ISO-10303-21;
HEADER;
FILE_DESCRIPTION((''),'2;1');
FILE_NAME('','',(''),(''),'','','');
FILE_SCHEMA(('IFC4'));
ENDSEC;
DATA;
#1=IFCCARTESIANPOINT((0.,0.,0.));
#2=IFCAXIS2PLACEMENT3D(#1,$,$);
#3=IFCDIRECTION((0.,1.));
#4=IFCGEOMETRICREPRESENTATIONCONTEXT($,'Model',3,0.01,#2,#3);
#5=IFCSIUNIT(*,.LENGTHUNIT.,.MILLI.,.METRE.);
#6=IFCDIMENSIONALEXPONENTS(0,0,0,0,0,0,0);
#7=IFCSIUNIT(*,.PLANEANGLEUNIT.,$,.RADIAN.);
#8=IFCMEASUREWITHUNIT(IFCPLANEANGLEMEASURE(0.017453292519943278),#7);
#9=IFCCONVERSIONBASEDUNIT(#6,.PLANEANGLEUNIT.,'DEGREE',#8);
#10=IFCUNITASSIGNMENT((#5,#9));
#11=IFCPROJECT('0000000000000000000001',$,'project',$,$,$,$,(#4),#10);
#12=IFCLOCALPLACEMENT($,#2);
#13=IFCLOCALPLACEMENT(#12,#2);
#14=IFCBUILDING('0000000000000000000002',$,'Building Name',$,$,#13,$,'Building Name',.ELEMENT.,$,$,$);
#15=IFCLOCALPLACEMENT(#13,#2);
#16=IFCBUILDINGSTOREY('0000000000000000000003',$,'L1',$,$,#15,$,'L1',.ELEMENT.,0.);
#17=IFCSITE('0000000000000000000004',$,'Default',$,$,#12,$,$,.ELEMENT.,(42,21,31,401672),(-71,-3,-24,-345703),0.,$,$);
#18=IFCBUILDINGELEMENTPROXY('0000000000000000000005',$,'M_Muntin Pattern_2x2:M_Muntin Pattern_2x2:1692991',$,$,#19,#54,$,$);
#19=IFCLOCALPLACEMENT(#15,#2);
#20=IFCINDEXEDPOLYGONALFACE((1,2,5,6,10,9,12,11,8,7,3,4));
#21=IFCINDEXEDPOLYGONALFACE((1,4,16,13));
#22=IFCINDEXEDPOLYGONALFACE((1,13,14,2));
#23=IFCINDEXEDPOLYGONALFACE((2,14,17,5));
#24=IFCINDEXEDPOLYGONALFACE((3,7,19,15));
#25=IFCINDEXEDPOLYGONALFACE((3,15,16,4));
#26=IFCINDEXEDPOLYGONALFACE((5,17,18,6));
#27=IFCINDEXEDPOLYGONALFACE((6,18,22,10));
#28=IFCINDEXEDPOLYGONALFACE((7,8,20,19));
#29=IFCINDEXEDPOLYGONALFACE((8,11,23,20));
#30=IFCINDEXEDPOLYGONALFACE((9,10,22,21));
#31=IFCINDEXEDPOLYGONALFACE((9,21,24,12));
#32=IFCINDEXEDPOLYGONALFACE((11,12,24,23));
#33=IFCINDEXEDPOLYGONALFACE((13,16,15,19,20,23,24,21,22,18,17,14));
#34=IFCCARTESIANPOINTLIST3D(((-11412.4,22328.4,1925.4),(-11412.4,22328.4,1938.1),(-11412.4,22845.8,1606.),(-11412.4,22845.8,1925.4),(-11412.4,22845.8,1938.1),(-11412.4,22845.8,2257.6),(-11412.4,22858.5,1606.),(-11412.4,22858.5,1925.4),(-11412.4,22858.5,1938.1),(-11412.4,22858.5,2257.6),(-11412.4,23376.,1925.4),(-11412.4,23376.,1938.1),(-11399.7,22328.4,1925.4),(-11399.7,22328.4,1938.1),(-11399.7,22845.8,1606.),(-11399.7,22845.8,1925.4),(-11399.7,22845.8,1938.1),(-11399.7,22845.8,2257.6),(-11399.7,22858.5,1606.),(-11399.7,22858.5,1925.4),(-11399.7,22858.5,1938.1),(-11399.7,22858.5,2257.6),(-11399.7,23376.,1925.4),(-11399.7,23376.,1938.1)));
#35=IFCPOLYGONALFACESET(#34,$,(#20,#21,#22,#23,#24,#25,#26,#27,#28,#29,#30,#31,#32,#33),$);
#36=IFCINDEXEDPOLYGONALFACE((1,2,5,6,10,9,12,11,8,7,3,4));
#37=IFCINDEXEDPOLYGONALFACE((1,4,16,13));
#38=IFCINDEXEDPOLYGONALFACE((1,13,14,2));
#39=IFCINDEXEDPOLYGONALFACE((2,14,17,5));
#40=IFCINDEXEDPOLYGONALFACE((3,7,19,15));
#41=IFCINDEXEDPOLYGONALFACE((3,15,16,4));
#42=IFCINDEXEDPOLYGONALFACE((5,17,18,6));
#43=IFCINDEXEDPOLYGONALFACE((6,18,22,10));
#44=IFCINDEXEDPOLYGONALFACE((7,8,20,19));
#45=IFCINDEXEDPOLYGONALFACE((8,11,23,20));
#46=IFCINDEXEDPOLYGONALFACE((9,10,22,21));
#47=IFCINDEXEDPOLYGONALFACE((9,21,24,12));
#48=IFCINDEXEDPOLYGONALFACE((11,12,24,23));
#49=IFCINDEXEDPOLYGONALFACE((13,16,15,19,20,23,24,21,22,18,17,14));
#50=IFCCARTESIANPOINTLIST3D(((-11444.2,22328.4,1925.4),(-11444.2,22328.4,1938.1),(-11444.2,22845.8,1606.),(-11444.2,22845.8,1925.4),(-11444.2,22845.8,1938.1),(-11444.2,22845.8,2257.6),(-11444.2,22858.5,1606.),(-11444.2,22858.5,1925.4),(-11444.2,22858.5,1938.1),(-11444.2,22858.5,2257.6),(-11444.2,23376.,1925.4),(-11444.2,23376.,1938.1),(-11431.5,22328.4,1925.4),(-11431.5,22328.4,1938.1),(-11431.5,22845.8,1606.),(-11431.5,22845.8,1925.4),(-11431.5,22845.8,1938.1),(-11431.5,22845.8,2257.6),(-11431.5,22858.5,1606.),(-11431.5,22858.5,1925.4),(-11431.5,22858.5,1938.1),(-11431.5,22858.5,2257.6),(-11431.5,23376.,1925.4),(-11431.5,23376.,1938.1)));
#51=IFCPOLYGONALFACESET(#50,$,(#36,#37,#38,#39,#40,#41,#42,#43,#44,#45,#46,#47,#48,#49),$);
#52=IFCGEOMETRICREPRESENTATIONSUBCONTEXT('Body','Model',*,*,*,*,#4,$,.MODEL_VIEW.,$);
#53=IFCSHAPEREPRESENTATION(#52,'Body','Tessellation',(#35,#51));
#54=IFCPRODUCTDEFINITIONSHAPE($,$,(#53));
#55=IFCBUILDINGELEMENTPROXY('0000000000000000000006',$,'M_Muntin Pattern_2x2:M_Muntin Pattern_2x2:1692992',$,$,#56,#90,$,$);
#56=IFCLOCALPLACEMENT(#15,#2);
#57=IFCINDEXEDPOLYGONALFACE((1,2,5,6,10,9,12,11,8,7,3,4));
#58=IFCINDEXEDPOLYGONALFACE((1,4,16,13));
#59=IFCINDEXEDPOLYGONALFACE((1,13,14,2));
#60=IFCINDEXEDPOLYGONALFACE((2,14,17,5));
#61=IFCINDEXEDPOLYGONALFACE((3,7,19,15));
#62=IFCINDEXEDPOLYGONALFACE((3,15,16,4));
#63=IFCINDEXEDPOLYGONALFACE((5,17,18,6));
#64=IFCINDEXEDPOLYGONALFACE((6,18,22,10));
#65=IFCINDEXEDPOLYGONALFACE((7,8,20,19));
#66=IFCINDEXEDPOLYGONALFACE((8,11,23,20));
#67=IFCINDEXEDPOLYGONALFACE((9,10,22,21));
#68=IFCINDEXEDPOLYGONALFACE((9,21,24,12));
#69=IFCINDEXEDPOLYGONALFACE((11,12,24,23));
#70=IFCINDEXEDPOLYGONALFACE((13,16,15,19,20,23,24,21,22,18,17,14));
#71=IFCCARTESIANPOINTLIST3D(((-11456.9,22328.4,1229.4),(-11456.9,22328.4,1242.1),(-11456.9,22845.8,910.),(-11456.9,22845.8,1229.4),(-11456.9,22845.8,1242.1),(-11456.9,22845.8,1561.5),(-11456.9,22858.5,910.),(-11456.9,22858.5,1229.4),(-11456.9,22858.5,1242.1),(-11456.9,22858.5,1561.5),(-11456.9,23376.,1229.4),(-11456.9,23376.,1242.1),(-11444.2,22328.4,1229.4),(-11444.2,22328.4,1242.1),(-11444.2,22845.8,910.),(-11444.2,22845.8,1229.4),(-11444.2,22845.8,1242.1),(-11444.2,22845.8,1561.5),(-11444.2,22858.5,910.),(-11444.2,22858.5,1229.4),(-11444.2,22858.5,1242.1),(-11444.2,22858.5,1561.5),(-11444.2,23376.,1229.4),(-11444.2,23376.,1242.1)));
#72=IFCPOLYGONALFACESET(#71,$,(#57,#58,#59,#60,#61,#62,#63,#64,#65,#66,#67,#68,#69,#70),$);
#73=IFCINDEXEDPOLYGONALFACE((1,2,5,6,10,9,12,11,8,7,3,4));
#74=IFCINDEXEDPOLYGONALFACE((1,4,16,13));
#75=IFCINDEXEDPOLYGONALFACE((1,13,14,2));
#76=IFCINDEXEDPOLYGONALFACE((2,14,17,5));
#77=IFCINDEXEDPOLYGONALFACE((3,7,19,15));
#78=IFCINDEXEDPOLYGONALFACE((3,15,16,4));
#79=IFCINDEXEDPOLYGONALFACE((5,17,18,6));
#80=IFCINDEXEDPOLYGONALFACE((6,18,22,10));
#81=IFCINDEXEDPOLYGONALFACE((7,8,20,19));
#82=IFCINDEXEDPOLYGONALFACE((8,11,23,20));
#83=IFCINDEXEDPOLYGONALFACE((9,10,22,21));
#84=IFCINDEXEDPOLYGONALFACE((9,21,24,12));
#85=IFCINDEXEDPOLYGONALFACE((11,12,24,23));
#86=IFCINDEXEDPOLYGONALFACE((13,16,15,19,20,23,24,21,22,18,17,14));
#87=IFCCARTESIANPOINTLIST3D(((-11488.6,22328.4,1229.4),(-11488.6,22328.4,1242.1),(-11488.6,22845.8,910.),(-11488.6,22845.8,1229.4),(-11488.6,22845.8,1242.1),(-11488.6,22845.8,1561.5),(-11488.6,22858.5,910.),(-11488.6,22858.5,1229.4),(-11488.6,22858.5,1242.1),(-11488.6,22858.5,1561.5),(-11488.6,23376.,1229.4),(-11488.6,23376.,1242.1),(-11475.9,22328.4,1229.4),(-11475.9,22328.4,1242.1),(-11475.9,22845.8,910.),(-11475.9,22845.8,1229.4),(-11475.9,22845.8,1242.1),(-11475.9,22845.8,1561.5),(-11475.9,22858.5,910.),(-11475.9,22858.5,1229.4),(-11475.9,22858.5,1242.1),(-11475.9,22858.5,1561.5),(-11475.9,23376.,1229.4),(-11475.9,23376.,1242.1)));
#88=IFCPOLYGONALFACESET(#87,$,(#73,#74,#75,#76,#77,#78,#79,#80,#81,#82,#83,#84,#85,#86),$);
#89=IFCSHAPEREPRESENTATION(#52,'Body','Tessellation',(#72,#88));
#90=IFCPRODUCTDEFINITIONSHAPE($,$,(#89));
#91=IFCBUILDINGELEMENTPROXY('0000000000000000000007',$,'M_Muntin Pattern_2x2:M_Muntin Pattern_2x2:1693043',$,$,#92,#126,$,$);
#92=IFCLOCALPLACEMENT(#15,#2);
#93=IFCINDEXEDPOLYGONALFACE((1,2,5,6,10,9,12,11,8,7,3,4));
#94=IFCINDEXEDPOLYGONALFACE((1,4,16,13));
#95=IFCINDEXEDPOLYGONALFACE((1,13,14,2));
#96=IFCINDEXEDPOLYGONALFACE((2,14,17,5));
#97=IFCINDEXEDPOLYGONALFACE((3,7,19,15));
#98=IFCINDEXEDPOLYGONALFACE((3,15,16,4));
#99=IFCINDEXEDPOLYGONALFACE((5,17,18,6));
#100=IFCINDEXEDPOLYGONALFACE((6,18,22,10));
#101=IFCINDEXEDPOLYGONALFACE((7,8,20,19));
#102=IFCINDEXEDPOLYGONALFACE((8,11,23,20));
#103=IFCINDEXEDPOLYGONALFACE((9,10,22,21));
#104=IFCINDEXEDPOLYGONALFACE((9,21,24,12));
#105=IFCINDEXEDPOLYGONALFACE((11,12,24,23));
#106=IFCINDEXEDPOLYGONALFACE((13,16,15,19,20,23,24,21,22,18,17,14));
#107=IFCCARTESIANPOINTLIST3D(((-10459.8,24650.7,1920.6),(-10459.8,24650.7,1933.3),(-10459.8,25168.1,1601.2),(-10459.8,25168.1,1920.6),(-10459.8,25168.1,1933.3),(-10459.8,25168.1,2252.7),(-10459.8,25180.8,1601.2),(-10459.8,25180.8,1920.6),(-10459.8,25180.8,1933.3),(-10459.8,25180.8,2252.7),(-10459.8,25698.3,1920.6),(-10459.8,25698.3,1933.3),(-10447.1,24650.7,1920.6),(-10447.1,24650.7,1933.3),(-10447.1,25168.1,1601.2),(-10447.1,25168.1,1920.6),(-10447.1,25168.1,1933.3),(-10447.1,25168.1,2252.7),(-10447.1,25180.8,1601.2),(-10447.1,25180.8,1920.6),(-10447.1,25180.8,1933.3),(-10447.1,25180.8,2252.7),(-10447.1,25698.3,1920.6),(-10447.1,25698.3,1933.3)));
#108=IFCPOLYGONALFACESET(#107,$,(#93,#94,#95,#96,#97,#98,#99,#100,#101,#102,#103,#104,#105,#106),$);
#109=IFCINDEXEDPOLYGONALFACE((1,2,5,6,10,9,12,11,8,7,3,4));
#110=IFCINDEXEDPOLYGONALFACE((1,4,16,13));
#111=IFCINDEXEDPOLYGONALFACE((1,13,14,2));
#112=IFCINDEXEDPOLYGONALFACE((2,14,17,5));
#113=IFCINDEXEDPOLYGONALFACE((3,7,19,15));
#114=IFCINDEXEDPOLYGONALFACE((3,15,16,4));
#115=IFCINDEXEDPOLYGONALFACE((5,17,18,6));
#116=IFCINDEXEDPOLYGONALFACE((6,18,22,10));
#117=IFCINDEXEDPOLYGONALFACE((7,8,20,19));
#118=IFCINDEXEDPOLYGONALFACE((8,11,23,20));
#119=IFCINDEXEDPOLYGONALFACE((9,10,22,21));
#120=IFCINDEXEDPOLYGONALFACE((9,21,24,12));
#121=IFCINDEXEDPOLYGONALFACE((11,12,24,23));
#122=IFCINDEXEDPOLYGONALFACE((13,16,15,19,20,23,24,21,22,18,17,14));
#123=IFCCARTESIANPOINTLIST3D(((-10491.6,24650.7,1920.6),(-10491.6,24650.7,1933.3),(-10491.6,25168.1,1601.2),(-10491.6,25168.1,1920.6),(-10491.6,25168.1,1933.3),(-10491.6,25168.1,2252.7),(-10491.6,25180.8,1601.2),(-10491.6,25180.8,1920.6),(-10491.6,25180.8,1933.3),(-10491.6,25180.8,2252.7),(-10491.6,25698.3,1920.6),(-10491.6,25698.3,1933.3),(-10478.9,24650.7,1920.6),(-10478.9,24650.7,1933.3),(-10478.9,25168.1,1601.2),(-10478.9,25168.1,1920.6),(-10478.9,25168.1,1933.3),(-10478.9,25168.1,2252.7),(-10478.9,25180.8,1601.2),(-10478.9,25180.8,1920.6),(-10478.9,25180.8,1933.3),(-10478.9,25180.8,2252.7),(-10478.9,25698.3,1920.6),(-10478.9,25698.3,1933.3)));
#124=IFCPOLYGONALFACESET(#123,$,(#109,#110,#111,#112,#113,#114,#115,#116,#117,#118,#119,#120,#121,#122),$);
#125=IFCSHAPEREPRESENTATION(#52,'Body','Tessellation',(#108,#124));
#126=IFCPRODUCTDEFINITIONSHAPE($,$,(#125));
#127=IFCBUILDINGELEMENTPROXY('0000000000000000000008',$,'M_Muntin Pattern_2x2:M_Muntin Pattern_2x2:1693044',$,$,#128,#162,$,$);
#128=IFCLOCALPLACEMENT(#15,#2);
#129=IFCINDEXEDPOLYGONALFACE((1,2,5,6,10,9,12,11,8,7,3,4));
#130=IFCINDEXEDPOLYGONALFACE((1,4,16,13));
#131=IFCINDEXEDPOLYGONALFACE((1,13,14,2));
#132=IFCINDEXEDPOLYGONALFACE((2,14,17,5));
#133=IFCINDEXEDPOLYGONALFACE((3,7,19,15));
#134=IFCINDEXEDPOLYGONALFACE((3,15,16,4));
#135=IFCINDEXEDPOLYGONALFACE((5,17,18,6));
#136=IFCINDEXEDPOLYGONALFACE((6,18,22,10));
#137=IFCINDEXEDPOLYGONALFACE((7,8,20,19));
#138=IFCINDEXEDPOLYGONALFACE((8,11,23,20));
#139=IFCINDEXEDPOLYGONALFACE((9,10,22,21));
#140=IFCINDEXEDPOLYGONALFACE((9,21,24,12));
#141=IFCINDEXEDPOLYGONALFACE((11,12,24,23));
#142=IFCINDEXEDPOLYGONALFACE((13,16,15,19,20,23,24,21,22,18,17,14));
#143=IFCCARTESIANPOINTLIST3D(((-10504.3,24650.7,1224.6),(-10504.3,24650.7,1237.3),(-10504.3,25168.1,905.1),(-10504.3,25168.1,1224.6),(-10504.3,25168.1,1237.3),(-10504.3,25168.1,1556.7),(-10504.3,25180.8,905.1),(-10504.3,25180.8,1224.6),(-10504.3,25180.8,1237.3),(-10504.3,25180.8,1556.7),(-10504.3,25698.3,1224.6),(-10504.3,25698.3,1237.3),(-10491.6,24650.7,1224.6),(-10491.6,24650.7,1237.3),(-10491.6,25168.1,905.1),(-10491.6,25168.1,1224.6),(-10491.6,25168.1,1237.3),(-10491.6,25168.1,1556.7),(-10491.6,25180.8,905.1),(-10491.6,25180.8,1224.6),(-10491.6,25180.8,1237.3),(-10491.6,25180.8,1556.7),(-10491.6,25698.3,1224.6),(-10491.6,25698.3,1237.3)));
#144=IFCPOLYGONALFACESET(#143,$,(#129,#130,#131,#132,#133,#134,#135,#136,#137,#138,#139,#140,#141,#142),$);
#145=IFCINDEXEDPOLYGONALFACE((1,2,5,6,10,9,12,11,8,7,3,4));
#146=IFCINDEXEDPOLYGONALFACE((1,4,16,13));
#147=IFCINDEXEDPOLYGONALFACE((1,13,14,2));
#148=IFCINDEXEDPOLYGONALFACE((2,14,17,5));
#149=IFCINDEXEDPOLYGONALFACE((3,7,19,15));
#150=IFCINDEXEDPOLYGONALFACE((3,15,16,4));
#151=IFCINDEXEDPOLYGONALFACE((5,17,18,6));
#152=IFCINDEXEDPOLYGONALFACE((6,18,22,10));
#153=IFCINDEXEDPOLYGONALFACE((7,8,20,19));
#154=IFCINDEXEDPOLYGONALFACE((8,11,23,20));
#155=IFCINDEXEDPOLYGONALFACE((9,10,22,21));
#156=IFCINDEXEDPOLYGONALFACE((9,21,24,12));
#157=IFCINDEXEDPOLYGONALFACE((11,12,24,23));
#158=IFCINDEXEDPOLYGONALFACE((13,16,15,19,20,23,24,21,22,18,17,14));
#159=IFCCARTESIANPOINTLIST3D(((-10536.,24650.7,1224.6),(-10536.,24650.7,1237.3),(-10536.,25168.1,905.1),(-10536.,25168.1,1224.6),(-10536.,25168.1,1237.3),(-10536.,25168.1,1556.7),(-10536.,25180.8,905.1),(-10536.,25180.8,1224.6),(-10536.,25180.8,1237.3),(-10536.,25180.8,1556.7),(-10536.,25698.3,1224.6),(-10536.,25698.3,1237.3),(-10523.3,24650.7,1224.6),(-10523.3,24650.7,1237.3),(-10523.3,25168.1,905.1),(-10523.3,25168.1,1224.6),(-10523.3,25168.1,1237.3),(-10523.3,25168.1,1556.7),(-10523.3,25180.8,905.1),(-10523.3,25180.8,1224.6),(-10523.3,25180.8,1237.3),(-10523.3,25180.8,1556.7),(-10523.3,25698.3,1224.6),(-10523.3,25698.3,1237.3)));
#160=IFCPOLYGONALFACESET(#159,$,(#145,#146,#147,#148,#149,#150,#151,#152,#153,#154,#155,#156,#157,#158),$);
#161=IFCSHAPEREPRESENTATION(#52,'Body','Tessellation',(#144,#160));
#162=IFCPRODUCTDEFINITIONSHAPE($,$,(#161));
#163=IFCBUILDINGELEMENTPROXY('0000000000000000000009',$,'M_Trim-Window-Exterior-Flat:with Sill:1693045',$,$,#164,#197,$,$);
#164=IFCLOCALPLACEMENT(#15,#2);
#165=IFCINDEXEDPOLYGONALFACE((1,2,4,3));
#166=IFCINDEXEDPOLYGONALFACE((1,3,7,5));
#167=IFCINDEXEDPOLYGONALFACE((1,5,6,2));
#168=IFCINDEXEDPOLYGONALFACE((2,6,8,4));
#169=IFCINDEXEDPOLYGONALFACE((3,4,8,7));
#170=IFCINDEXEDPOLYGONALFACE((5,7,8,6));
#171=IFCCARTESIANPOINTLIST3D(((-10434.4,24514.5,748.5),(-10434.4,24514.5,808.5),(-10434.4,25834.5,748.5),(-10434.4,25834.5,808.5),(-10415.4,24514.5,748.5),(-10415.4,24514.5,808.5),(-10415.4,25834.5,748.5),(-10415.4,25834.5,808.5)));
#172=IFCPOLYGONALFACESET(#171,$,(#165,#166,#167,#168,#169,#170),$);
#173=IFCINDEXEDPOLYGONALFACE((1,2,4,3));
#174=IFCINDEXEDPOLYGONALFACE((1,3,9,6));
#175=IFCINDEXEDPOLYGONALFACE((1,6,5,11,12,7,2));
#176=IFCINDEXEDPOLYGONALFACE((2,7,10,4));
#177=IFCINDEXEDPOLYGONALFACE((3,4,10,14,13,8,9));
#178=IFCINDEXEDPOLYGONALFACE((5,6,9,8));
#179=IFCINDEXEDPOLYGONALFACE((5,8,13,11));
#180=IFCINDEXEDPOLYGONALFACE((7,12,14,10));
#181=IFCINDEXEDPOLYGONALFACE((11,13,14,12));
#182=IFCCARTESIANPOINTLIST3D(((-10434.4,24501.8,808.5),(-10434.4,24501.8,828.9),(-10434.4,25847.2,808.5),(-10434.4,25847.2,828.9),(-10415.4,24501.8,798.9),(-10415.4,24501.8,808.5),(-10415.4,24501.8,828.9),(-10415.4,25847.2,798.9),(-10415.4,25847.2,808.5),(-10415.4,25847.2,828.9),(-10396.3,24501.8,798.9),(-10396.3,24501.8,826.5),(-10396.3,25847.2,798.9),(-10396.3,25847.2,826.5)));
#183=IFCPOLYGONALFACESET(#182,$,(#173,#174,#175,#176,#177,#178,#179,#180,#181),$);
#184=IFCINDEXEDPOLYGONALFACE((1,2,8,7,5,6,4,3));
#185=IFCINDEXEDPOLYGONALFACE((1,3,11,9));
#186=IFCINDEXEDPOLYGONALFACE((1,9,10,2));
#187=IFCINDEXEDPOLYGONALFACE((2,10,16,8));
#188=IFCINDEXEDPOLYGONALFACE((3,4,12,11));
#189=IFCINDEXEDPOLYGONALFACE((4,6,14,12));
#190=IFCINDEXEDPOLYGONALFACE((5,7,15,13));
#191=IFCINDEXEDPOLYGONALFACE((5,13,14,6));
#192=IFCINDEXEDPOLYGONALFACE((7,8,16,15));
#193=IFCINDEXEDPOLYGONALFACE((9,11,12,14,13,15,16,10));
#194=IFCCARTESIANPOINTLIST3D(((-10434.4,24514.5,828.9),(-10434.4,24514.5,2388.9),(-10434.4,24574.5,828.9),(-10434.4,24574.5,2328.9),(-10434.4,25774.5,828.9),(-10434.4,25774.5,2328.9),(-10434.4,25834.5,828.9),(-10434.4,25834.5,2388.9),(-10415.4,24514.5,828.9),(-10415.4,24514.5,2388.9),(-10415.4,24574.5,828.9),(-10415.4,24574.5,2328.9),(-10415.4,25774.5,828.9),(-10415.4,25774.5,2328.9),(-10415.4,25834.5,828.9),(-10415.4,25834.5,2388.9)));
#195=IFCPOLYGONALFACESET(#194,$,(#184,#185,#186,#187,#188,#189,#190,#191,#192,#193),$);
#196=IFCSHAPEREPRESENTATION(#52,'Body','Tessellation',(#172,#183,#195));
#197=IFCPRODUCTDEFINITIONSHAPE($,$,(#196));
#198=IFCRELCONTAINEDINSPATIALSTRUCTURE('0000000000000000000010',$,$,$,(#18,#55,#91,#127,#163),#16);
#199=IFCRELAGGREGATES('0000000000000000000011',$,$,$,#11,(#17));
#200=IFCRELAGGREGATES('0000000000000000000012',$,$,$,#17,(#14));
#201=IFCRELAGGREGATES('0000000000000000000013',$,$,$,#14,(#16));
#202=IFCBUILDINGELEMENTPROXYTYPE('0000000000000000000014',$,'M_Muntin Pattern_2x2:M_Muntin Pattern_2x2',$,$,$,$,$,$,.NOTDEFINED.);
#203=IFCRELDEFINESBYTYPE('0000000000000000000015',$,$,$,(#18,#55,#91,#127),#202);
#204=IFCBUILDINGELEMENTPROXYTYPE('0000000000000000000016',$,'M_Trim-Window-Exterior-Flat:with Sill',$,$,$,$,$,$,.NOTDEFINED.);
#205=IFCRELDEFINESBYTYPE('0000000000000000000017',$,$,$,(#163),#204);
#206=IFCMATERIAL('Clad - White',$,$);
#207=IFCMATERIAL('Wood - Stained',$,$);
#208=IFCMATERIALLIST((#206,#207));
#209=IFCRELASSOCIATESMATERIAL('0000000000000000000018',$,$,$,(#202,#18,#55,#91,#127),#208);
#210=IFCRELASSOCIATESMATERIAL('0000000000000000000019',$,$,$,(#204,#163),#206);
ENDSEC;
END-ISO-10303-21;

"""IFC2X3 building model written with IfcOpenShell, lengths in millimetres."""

from ifc_helpers import new_model, entity, si_unit, converted_unit, direction, frame, frame_2d, origin, place, context, subcontext, project, spatial, polyline, rectangle, outline, extrude, source, transform, mapped, material, material_list, type_object, type_shapes, element, save


model = new_model("IFC2X3")

# Units and contexts
model_context = context("Model", 3, precision=0.01, world=origin(), true_north=direction((0.0, 1.0)))
body_context = subcontext(model_context, "Body", "Model", "MODEL_VIEW")
ifc_project = project(units=[si_unit("LENGTHUNIT", "METRE", prefix="MILLI"), converted_unit("PLANEANGLEUNIT", "DEGREE", entity("IfcPlaneAngleMeasure", 0.017453292519943278), si_unit("PLANEANGLEUNIT", "RADIAN"), dimensions=[0, 0, 0, 0, 0, 0, 0])], contexts=[model_context])

# Site, building, storey
site_placement = place(None, origin())
site = spatial("IfcSite", under=ifc_project, at=site_placement, Name="Default", CompositionType="ELEMENT", RefLatitude=(42, 21, 31, 401672), RefLongitude=(-71, -3, -24, -345703), RefElevation=0.0)
building_placement = place(site_placement, origin())
building = spatial("IfcBuilding", under=site, at=building_placement, Name="Building Name", LongName="Building Name", CompositionType="ELEMENT")
storey_placement = place(building_placement, origin())
storey = spatial("IfcBuildingStorey", under=building, at=storey_placement, Name="L1", LongName="L1", CompositionType="ELEMENT", Elevation=0.0)

# Shared definitions
ifc_material_1 = material(Name="Wood - Stained")

# Building element proxies
ifc_material_2 = material(Name="Clad - White")
ifc_material_list_1 = material_list([ifc_material_2, ifc_material_1])
building_element_proxy_type_1 = type_object("IfcBuildingElementProxyType", Name="M_Muntin Pattern_2x2:M_Muntin Pattern_2x2", PredefinedType="NOTDEFINED", material=ifc_material_list_1)
shared_shape_1 = source(origin(), body_context, "Body", "SweptSolid", [
    extrude(outline(polyline([(6.4, -6.4), (325.8, -6.4), (325.8, 6.3), (6.4, 6.3), (6.4, 523.8), (-6.3, 523.8), (-6.3, 6.3), (-325.8, 6.3), (-325.8, -6.4), (-6.3, -6.4), (-6.3, -523.8), (6.4, -523.8), (6.4, -6.4)])), frame((0.0, 9.5, 325.8), z_axis=(0.0, 1.0, 0.0), x_axis=(0.0, 0.0, 1.0)), (0.0, 0.0, 1.0), 12.7),
    extrude(outline(polyline([(6.4, -6.4), (325.8, -6.4), (325.8, 6.3), (6.4, 6.3), (6.4, 523.8), (-6.3, 523.8), (-6.3, 6.3), (-325.8, 6.3), (-325.8, -6.4), (-6.3, -6.4), (-6.3, -523.8), (6.4, -523.8), (6.4, -6.4)])), frame((0.0, -22.2, 325.8), z_axis=(0.0, 1.0, 0.0), x_axis=(0.0, 0.0, 1.0)), (0.0, 0.0, 1.0), 12.7),
])
type_shapes(building_element_proxy_type_1, [shared_shape_1])
for number, where, z_axis, x_axis, name in (
    (1, (-11422.0, 22852.2, 1606.0), (0.0, 0.0, 1.0), (0.0, -1.0, 0.0), "M_Muntin Pattern_2x2:M_Muntin Pattern_2x2:1692991"),
    (2, (-11466.4, 22852.2, 910.0), (0.0, 0.0, 1.0), (0.0, -1.0, 0.0), "M_Muntin Pattern_2x2:M_Muntin Pattern_2x2:1692992"),
    (3, (-10469.3, 25174.5, 1601.2), (0.0, 0.0, 1.0), (0.0, -1.0, 0.0), "M_Muntin Pattern_2x2:M_Muntin Pattern_2x2:1693043"),
    (4, (-10513.8, 25174.5, 905.1), (0.0, 0.0, 1.0), (0.0, -1.0, 0.0), "M_Muntin Pattern_2x2:M_Muntin Pattern_2x2:1693044"),
):
    element("IfcBuildingElementProxy", number, at=place(storey_placement, frame(where, z_axis=z_axis, x_axis=x_axis)), inside=storey, type_object=building_element_proxy_type_1, material=ifc_material_list_1, Name=name, context=body_context, shape_type="MappedRepresentation", body=[
        mapped(shared_shape_1, transform((0.0, 0.0, 0.0), scale=1.0)),
    ])
building_element_proxy_type_2 = type_object("IfcBuildingElementProxyType", Name="M_Trim-Window-Exterior-Flat:with Sill", PredefinedType="NOTDEFINED", material=ifc_material_2)
shared_shape_2 = source(origin(), body_context, "Body", "SweptSolid", [
    extrude(rectangle(XDim=1320.0, YDim=60.0, at=frame_2d((0.0, 0.0), x_axis=(1.0, 0.0))), frame((0.0, -1550.4, 0.0), z_axis=(0.0, 0.0, 1.0), x_axis=(-1.0, 0.0, 0.0)), (0.0, 0.0, 1.0), 19.0),
    extrude(outline(polyline([(-19.0, -15.2), (0.0, -15.2), (0.0, -5.7), (19.0, -5.7), (19.0, 14.8), (0.0, 14.8), (-19.0, 12.3), (-19.0, -15.2)])), frame((-672.7, -1514.8, 19.0), z_axis=(1.0, 0.0, 0.0), x_axis=(0.0, 0.0, -1.0)), (0.0, 0.0, 1.0), 1345.4),
    extrude(outline(polyline([(-795.0, -660.0), (765.0, -660.0), (765.0, -600.0), (-735.0, -600.0), (-735.0, 600.0), (765.0, 600.0), (765.0, 660.0), (-795.0, 660.0), (-795.0, -660.0)])), frame((0.0, -735.0, 0.0), z_axis=(0.0, 0.0, 1.0), x_axis=(0.0, -1.0, 0.0)), (0.0, 0.0, 1.0), 19.0),
])
type_shapes(building_element_proxy_type_2, [shared_shape_2])
proxy_1_placement = place(storey_placement, frame((-10434.4, 25174.5, 2328.9), z_axis=(1.0, 0.0, 0.0), x_axis=(0.0, 1.0, 0.0)))
element("IfcBuildingElementProxy", 5, at=proxy_1_placement, inside=storey, type_object=building_element_proxy_type_2, material=ifc_material_2, Name="M_Trim-Window-Exterior-Flat:with Sill:1693045", context=body_context, shape_type="MappedRepresentation", body=[
    mapped(shared_shape_2, transform((0.0, 0.0, 0.0), scale=1.0)),
])

save(model, "model.ifc")
